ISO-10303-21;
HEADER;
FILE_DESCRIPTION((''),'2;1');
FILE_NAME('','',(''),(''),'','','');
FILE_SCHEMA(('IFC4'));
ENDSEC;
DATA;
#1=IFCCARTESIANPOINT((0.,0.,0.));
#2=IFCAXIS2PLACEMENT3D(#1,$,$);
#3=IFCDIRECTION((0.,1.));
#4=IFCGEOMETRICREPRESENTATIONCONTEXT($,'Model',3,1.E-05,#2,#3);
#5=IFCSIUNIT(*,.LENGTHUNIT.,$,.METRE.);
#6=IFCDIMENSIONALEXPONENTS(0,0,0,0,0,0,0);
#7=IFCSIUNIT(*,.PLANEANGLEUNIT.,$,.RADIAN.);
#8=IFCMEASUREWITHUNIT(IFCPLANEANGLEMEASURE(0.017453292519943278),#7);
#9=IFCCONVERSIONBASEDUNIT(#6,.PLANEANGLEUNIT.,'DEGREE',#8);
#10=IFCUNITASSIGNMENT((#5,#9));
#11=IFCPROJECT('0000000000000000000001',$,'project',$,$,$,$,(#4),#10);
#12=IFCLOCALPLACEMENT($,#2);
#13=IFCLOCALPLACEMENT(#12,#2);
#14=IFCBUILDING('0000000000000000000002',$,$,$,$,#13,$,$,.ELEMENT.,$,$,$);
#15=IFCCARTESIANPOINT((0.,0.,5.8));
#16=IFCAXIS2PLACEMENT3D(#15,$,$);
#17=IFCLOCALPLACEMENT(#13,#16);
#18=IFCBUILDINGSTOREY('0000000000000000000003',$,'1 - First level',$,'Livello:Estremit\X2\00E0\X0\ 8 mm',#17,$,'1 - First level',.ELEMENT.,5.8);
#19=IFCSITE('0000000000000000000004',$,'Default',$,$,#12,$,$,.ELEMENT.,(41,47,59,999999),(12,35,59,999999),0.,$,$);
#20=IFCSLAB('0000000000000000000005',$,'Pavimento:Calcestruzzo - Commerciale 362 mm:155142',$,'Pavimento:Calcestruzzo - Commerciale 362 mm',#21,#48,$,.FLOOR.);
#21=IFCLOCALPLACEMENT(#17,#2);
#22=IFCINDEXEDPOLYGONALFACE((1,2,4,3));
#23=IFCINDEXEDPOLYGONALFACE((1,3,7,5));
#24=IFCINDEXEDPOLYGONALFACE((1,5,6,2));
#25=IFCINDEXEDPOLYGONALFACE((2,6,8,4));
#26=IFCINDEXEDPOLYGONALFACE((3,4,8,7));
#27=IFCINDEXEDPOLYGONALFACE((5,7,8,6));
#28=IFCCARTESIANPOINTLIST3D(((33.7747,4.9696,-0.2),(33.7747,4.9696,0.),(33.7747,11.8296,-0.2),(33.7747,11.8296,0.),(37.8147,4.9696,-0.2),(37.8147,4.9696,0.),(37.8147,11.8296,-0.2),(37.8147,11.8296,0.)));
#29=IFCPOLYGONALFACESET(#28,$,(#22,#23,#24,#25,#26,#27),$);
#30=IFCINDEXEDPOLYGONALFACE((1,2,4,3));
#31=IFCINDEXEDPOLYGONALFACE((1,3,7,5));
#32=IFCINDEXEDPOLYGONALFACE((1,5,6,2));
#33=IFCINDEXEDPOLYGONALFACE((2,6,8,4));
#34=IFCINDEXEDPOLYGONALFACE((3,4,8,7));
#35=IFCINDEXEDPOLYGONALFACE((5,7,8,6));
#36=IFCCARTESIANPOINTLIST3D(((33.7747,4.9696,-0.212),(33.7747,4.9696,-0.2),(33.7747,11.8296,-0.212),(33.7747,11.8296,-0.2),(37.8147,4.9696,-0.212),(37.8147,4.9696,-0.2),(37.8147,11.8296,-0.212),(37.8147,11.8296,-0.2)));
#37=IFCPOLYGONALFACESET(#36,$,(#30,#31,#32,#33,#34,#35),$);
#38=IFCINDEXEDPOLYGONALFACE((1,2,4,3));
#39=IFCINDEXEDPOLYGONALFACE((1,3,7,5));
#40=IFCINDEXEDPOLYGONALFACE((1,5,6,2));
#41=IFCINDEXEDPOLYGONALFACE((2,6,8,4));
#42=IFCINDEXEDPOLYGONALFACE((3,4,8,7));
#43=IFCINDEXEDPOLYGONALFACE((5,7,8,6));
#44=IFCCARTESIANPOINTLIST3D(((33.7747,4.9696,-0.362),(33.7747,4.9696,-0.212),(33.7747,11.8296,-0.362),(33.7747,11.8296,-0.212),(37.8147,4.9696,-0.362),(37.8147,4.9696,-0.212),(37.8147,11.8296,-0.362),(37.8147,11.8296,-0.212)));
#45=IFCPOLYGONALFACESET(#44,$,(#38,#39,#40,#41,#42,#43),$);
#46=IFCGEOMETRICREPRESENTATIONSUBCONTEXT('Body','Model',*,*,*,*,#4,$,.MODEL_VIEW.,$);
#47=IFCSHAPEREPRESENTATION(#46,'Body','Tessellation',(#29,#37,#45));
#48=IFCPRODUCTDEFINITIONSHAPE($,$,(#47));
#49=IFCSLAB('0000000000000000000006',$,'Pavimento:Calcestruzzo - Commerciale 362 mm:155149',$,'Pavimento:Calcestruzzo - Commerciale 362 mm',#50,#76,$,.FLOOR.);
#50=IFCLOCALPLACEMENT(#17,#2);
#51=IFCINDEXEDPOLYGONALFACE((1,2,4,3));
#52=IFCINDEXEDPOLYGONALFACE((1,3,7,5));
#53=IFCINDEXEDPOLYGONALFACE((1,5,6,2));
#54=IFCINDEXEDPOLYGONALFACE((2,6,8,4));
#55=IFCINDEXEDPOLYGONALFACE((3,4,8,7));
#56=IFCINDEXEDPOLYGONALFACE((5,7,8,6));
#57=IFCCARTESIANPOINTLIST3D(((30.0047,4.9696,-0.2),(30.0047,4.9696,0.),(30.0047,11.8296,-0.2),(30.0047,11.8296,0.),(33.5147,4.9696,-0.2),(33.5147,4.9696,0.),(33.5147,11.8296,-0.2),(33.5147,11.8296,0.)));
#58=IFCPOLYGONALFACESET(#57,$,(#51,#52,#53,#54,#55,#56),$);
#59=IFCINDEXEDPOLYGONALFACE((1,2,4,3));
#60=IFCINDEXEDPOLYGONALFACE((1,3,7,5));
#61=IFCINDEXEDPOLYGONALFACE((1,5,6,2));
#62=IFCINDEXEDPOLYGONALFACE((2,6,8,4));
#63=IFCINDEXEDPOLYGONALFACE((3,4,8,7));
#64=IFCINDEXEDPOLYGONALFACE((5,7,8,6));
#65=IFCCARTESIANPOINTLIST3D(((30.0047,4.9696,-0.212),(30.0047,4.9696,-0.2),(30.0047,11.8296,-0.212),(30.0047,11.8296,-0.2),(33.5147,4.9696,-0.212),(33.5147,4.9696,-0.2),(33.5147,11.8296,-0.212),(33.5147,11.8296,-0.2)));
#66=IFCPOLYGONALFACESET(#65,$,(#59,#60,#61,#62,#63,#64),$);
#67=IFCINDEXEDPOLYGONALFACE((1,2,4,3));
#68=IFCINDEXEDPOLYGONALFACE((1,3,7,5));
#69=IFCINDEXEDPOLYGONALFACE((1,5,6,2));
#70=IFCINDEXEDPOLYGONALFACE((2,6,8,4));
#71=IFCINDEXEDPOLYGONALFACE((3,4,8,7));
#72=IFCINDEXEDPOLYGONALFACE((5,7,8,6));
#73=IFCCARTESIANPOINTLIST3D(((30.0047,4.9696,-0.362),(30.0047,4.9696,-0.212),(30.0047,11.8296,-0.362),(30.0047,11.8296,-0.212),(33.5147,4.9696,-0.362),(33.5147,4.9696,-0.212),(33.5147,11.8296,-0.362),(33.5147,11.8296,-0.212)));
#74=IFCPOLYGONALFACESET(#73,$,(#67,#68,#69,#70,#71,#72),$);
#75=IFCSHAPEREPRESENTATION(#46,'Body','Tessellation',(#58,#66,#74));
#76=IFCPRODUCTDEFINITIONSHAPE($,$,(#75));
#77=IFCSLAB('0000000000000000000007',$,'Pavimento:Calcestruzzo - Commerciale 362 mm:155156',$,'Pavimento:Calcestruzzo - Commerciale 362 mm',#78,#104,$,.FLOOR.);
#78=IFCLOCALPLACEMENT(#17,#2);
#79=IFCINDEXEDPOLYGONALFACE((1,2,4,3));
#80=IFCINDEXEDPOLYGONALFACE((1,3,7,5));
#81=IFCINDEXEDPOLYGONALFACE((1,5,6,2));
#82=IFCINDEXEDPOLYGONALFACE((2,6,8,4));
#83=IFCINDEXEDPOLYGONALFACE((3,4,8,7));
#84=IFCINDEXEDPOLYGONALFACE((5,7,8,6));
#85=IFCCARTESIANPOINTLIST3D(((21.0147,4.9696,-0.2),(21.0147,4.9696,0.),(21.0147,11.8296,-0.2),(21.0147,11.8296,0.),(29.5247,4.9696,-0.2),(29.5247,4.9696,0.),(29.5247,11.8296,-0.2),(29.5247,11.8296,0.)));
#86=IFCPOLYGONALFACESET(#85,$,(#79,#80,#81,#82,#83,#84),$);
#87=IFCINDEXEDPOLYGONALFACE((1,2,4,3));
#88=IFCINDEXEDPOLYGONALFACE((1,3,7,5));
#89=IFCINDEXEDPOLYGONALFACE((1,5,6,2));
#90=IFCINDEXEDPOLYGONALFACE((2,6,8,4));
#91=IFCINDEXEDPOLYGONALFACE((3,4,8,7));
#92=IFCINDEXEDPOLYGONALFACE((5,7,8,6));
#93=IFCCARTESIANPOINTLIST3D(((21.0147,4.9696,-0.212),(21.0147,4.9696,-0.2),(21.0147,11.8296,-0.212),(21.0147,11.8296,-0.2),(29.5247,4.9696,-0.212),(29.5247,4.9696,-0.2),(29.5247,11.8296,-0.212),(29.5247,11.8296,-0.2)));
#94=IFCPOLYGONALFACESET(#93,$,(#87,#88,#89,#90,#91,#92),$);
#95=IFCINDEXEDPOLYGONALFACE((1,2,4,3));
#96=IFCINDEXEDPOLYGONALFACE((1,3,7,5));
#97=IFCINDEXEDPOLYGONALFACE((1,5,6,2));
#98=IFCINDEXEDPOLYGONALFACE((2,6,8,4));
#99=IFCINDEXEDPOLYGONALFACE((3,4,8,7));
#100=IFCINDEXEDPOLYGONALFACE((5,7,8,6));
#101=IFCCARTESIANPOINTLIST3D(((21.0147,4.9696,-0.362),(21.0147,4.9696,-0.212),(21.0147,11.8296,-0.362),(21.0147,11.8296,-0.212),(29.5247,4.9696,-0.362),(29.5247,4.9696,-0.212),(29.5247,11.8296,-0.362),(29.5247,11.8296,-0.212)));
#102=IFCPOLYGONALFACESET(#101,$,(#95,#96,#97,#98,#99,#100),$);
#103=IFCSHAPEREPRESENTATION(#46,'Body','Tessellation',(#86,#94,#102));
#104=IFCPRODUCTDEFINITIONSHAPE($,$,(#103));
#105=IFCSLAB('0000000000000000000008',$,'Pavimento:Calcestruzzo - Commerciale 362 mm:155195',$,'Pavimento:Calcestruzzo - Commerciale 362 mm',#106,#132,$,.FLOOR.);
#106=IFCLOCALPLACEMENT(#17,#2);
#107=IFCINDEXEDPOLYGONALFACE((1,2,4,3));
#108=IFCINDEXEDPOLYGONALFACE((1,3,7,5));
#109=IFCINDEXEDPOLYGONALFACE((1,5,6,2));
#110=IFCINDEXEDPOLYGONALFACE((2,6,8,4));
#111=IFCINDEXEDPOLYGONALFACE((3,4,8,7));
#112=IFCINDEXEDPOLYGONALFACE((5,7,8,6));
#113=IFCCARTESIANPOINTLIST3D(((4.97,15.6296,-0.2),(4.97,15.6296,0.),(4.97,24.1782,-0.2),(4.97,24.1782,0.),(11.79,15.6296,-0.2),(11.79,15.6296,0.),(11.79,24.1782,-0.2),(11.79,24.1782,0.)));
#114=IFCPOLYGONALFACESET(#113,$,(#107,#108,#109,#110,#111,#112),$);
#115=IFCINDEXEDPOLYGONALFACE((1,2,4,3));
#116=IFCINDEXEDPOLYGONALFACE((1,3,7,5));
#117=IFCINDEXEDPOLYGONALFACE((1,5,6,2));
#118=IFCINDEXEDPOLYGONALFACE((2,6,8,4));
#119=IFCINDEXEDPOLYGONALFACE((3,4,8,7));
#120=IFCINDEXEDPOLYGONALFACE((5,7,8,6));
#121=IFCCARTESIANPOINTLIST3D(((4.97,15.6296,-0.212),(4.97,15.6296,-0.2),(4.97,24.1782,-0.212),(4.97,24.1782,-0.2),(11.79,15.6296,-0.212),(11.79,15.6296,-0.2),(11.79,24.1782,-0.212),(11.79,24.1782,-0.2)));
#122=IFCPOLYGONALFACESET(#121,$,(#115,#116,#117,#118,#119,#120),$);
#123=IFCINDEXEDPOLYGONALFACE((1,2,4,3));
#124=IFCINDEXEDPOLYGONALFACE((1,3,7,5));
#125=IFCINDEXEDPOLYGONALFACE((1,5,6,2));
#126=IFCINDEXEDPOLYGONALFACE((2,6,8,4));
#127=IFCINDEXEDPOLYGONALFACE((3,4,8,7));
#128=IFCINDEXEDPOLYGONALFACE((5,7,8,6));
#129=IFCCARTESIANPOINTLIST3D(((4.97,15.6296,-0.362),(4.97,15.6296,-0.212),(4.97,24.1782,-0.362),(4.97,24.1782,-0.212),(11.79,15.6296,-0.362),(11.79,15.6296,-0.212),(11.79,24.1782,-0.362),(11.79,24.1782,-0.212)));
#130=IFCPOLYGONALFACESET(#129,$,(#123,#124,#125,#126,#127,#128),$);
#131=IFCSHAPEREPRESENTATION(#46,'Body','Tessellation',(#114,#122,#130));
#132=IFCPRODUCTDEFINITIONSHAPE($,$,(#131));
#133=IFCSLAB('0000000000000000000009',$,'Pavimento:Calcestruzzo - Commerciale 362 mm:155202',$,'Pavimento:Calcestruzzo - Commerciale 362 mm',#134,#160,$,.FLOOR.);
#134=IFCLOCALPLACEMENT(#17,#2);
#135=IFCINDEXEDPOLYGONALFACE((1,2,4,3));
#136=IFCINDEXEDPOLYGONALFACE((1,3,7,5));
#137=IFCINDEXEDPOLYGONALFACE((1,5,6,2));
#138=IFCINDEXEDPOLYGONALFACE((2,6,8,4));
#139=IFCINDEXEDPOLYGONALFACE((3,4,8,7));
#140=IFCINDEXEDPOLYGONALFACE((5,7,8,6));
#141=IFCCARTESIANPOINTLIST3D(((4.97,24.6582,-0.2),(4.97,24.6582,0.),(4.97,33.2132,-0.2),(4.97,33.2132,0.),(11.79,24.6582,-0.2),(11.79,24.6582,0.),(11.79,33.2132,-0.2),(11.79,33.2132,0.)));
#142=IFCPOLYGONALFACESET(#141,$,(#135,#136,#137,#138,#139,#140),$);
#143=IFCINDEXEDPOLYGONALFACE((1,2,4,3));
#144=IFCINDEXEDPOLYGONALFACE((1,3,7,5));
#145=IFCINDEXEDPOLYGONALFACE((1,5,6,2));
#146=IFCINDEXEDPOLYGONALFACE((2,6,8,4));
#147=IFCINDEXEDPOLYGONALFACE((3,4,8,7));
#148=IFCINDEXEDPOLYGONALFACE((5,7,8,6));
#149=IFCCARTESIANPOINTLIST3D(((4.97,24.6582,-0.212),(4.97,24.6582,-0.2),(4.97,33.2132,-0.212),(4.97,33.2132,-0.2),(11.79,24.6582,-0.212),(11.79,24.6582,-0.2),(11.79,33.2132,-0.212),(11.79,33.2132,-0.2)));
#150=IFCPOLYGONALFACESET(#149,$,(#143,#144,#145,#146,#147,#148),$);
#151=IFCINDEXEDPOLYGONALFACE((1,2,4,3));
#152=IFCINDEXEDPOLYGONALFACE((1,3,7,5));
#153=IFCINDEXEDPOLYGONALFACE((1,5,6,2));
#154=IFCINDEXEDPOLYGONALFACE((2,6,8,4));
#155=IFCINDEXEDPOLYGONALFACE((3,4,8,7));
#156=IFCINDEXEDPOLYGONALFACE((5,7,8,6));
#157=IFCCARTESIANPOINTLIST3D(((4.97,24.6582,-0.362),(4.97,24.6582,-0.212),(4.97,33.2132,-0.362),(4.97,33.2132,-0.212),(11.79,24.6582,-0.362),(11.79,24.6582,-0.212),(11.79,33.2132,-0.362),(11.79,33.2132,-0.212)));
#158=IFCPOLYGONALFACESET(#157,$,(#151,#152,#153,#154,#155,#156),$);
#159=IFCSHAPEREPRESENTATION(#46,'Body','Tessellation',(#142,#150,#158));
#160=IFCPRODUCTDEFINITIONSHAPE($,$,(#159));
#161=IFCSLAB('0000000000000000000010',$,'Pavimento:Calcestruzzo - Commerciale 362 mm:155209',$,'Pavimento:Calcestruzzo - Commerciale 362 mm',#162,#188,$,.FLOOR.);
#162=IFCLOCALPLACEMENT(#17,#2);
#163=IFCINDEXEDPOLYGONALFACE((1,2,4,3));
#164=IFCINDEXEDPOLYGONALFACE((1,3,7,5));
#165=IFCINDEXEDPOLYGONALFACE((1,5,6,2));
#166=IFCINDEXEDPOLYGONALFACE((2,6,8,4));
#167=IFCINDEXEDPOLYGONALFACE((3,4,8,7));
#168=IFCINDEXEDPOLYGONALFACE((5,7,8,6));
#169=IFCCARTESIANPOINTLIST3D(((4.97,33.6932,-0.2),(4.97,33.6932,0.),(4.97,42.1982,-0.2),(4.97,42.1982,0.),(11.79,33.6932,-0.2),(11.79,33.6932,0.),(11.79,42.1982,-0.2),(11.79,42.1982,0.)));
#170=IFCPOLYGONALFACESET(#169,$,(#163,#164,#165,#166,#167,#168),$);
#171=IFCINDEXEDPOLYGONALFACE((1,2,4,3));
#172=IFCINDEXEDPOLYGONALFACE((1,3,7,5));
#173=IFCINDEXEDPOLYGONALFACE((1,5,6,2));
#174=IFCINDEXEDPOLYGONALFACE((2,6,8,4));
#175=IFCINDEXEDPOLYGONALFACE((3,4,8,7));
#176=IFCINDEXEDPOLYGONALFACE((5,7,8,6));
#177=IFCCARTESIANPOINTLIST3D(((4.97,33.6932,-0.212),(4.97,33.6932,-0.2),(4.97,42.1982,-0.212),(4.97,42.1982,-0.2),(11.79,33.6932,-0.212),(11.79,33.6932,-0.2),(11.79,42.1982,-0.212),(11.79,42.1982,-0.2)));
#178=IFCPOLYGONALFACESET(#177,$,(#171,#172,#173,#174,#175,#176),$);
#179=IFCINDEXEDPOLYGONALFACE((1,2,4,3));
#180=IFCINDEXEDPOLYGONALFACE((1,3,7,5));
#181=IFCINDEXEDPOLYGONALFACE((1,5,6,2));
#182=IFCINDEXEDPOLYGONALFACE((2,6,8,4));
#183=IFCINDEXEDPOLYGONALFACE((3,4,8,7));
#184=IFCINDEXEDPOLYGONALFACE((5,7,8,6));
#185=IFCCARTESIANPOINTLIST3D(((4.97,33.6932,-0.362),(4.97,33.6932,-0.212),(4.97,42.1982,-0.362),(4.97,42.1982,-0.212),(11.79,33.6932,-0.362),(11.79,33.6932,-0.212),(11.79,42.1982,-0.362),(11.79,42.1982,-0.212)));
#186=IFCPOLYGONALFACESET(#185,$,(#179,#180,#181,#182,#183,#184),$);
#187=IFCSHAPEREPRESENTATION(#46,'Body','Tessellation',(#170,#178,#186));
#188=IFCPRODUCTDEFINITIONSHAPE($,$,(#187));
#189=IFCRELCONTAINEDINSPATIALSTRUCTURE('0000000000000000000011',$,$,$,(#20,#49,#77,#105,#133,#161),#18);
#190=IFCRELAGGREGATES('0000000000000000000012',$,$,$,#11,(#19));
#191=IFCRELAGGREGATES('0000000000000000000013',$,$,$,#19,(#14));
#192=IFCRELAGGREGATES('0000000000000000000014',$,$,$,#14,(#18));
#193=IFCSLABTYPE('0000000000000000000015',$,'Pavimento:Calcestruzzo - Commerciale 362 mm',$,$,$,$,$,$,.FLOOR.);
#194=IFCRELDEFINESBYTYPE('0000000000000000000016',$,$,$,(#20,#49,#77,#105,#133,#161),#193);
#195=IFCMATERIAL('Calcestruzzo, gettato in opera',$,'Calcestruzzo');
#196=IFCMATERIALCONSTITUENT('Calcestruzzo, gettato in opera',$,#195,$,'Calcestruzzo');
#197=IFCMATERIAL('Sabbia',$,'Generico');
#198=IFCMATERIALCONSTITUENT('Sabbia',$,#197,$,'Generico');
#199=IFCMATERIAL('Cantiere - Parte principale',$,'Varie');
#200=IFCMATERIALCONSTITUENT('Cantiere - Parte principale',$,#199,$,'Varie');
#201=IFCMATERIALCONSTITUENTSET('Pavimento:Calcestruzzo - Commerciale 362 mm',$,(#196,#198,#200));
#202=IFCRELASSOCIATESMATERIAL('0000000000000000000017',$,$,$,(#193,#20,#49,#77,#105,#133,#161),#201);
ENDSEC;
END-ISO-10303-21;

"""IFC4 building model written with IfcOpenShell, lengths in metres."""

from ifc_helpers import new_model, entity, si_unit, converted_unit, direction, frame, origin, place, context, subcontext, project, spatial, indexed_curve, outline, extrude, material, constituent, constituent_set, type_object, element, save


model = new_model("IFC4")

# Units and contexts
model_context = context("Model", 3, precision=1e-05, world=origin(), true_north=direction((0.0, 1.0)))
body_context = subcontext(model_context, "Body", "Model", "MODEL_VIEW")
ifc_project = project(units=[si_unit("LENGTHUNIT", "METRE"), converted_unit("PLANEANGLEUNIT", "DEGREE", entity("IfcPlaneAngleMeasure", 0.017453292519943278), si_unit("PLANEANGLEUNIT", "RADIAN"), dimensions=[0, 0, 0, 0, 0, 0, 0])], contexts=[model_context])

# Site, building, storey
site_placement = place(None, origin())
site = spatial("IfcSite", under=ifc_project, at=site_placement, Name="Default", CompositionType="ELEMENT", RefLatitude=(41, 47, 59, 999999), RefLongitude=(12, 35, 59, 999999), RefElevation=0.0)
building_placement = place(site_placement, origin())
building = spatial("IfcBuilding", under=site, at=building_placement, CompositionType="ELEMENT")
storey_placement = place(building_placement, frame((0.0, 0.0, 5.8)))
storey = spatial("IfcBuildingStorey", under=building, at=storey_placement, Name="1 - First level", ObjectType="Livello:Estremità 8 mm", LongName="1 - First level", CompositionType="ELEMENT", Elevation=5.8)

# Slabs
ifc_material_1 = material(Name="Calcestruzzo, gettato in opera", Category="Calcestruzzo")
ifc_constituent_1 = constituent(ifc_material_1, Name="Calcestruzzo, gettato in opera", Category="Calcestruzzo")
ifc_material_2 = material(Name="Sabbia", Category="Generico")
ifc_constituent_2 = constituent(ifc_material_2, Name="Sabbia", Category="Generico")
ifc_material_3 = material(Name="Cantiere - Parte principale", Category="Varie")
ifc_constituent_3 = constituent(ifc_material_3, Name="Cantiere - Parte principale", Category="Varie")
ifc_constituent_set = constituent_set(constituents=[ifc_constituent_1, ifc_constituent_2, ifc_constituent_3], Name="Pavimento:Calcestruzzo - Commerciale 362 mm")
slab_type = type_object("IfcSlabType", Name="Pavimento:Calcestruzzo - Commerciale 362 mm", PredefinedType="FLOOR", material=ifc_constituent_set)
slab_1_placement = place(storey_placement, origin())
element("IfcSlab", 1, at=slab_1_placement, inside=storey, type_object=slab_type, material=ifc_constituent_set, Name="Pavimento:Calcestruzzo - Commerciale 362 mm:155142", ObjectType="Pavimento:Calcestruzzo - Commerciale 362 mm", PredefinedType="FLOOR", context=body_context, shape_type="SweptSolid", body=[
    extrude(outline(indexed_curve([(-2.02, -3.43), (2.02, -3.43), (2.02, 3.43), (-2.02, 3.43), (-2.02, -3.43)], self_intersect=False)), frame((35.7947, 8.3996, -0.2)), (0.0, 0.0, 1.0), 0.2),
    extrude(outline(indexed_curve([(-2.02, -3.43), (2.02, -3.43), (2.02, 3.43), (-2.02, 3.43), (-2.02, -3.43)], self_intersect=False)), frame((35.7947, 8.3996, -0.212)), (0.0, 0.0, 1.0), 0.012),
    extrude(outline(indexed_curve([(-2.02, -3.43), (2.02, -3.43), (2.02, 3.43), (-2.02, 3.43), (-2.02, -3.43)], self_intersect=False)), frame((35.7947, 8.3996, -0.362)), (0.0, 0.0, 1.0), 0.15),
])
slab_2_placement = place(storey_placement, origin())
element("IfcSlab", 2, at=slab_2_placement, inside=storey, type_object=slab_type, material=ifc_constituent_set, Name="Pavimento:Calcestruzzo - Commerciale 362 mm:155149", ObjectType="Pavimento:Calcestruzzo - Commerciale 362 mm", PredefinedType="FLOOR", context=body_context, shape_type="SweptSolid", body=[
    extrude(outline(indexed_curve([(-1.755, -3.43), (1.755, -3.43), (1.755, 3.43), (-1.755, 3.43), (-1.755, -3.43)], self_intersect=False)), frame((31.7597, 8.3996, -0.2)), (0.0, 0.0, 1.0), 0.2),
    extrude(outline(indexed_curve([(-1.755, -3.43), (1.755, -3.43), (1.755, 3.43), (-1.755, 3.43), (-1.755, -3.43)], self_intersect=False)), frame((31.7597, 8.3996, -0.212)), (0.0, 0.0, 1.0), 0.012),
    extrude(outline(indexed_curve([(-1.755, -3.43), (1.755, -3.43), (1.755, 3.43), (-1.755, 3.43), (-1.755, -3.43)], self_intersect=False)), frame((31.7597, 8.3996, -0.362)), (0.0, 0.0, 1.0), 0.15),
])
slab_3_placement = place(storey_placement, origin())
element("IfcSlab", 3, at=slab_3_placement, inside=storey, type_object=slab_type, material=ifc_constituent_set, Name="Pavimento:Calcestruzzo - Commerciale 362 mm:155156", ObjectType="Pavimento:Calcestruzzo - Commerciale 362 mm", PredefinedType="FLOOR", context=body_context, shape_type="SweptSolid", body=[
    extrude(outline(indexed_curve([(-3.43, -4.255), (3.43, -4.255), (3.43, 4.255), (-3.43, 4.255), (-3.43, -4.255)], self_intersect=False)), frame((25.2697, 8.3996, -0.2), z_axis=(0.0, 0.0, 1.0), x_axis=(0.0, 1.0, 0.0)), (0.0, 0.0, 1.0), 0.2),
    extrude(outline(indexed_curve([(-3.43, -4.255), (3.43, -4.255), (3.43, 4.255), (-3.43, 4.255), (-3.43, -4.255)], self_intersect=False)), frame((25.2697, 8.3996, -0.212), z_axis=(0.0, 0.0, 1.0), x_axis=(0.0, 1.0, 0.0)), (0.0, 0.0, 1.0), 0.012),
    extrude(outline(indexed_curve([(-3.43, -4.255), (3.43, -4.255), (3.43, 4.255), (-3.43, 4.255), (-3.43, -4.255)], self_intersect=False)), frame((25.2697, 8.3996, -0.362), z_axis=(0.0, 0.0, 1.0), x_axis=(0.0, 1.0, 0.0)), (0.0, 0.0, 1.0), 0.15),
])
slab_4_placement = place(storey_placement, origin())
element("IfcSlab", 4, at=slab_4_placement, inside=storey, type_object=slab_type, material=ifc_constituent_set, Name="Pavimento:Calcestruzzo - Commerciale 362 mm:155195", ObjectType="Pavimento:Calcestruzzo - Commerciale 362 mm", PredefinedType="FLOOR", context=body_context, shape_type="SweptSolid", body=[
    extrude(outline(indexed_curve([(-3.41, -4.2743), (3.41, -4.2743), (3.41, 4.2743), (-3.41, 4.2743), (-3.41, -4.2743)], self_intersect=False)), frame((8.38, 19.9039, -0.2), z_axis=(0.0, 0.0, 1.0), x_axis=(-1.0, 0.0, 0.0)), (0.0, 0.0, 1.0), 0.2),
    extrude(outline(indexed_curve([(-3.41, -4.2743), (3.41, -4.2743), (3.41, 4.2743), (-3.41, 4.2743), (-3.41, -4.2743)], self_intersect=False)), frame((8.38, 19.9039, -0.212), z_axis=(0.0, 0.0, 1.0), x_axis=(-1.0, 0.0, 0.0)), (0.0, 0.0, 1.0), 0.012),
    extrude(outline(indexed_curve([(-3.41, -4.2743), (3.41, -4.2743), (3.41, 4.2743), (-3.41, 4.2743), (-3.41, -4.2743)], self_intersect=False)), frame((8.38, 19.9039, -0.362), z_axis=(0.0, 0.0, 1.0), x_axis=(-1.0, 0.0, 0.0)), (0.0, 0.0, 1.0), 0.15),
])
slab_5_placement = place(storey_placement, origin())
element("IfcSlab", 5, at=slab_5_placement, inside=storey, type_object=slab_type, material=ifc_constituent_set, Name="Pavimento:Calcestruzzo - Commerciale 362 mm:155202", ObjectType="Pavimento:Calcestruzzo - Commerciale 362 mm", PredefinedType="FLOOR", context=body_context, shape_type="SweptSolid", body=[
    extrude(outline(indexed_curve([(-3.41, -4.2775), (3.41, -4.2775), (3.41, 4.2775), (-3.41, 4.2775), (-3.41, -4.2775)], self_intersect=False)), frame((8.38, 28.9357, -0.2)), (0.0, 0.0, 1.0), 0.2),
    extrude(outline(indexed_curve([(-3.41, -4.2775), (3.41, -4.2775), (3.41, 4.2775), (-3.41, 4.2775), (-3.41, -4.2775)], self_intersect=False)), frame((8.38, 28.9357, -0.212)), (0.0, 0.0, 1.0), 0.012),
    extrude(outline(indexed_curve([(-3.41, -4.2775), (3.41, -4.2775), (3.41, 4.2775), (-3.41, 4.2775), (-3.41, -4.2775)], self_intersect=False)), frame((8.38, 28.9357, -0.362)), (0.0, 0.0, 1.0), 0.15),
])
slab_6_placement = place(storey_placement, origin())
element("IfcSlab", 6, at=slab_6_placement, inside=storey, type_object=slab_type, material=ifc_constituent_set, Name="Pavimento:Calcestruzzo - Commerciale 362 mm:155209", ObjectType="Pavimento:Calcestruzzo - Commerciale 362 mm", PredefinedType="FLOOR", context=body_context, shape_type="SweptSolid", body=[
    extrude(outline(indexed_curve([(-3.41, -4.2525), (3.41, -4.2525), (3.41, 4.2525), (-3.41, 4.2525), (-3.41, -4.2525)], self_intersect=False)), frame((8.38, 37.9457, -0.2)), (0.0, 0.0, 1.0), 0.2),
    extrude(outline(indexed_curve([(-3.41, -4.2525), (3.41, -4.2525), (3.41, 4.2525), (-3.41, 4.2525), (-3.41, -4.2525)], self_intersect=False)), frame((8.38, 37.9457, -0.212)), (0.0, 0.0, 1.0), 0.012),
    extrude(outline(indexed_curve([(-3.41, -4.2525), (3.41, -4.2525), (3.41, 4.2525), (-3.41, 4.2525), (-3.41, -4.2525)], self_intersect=False)), frame((8.38, 37.9457, -0.362)), (0.0, 0.0, 1.0), 0.15),
])

save(model, "model.ifc")
